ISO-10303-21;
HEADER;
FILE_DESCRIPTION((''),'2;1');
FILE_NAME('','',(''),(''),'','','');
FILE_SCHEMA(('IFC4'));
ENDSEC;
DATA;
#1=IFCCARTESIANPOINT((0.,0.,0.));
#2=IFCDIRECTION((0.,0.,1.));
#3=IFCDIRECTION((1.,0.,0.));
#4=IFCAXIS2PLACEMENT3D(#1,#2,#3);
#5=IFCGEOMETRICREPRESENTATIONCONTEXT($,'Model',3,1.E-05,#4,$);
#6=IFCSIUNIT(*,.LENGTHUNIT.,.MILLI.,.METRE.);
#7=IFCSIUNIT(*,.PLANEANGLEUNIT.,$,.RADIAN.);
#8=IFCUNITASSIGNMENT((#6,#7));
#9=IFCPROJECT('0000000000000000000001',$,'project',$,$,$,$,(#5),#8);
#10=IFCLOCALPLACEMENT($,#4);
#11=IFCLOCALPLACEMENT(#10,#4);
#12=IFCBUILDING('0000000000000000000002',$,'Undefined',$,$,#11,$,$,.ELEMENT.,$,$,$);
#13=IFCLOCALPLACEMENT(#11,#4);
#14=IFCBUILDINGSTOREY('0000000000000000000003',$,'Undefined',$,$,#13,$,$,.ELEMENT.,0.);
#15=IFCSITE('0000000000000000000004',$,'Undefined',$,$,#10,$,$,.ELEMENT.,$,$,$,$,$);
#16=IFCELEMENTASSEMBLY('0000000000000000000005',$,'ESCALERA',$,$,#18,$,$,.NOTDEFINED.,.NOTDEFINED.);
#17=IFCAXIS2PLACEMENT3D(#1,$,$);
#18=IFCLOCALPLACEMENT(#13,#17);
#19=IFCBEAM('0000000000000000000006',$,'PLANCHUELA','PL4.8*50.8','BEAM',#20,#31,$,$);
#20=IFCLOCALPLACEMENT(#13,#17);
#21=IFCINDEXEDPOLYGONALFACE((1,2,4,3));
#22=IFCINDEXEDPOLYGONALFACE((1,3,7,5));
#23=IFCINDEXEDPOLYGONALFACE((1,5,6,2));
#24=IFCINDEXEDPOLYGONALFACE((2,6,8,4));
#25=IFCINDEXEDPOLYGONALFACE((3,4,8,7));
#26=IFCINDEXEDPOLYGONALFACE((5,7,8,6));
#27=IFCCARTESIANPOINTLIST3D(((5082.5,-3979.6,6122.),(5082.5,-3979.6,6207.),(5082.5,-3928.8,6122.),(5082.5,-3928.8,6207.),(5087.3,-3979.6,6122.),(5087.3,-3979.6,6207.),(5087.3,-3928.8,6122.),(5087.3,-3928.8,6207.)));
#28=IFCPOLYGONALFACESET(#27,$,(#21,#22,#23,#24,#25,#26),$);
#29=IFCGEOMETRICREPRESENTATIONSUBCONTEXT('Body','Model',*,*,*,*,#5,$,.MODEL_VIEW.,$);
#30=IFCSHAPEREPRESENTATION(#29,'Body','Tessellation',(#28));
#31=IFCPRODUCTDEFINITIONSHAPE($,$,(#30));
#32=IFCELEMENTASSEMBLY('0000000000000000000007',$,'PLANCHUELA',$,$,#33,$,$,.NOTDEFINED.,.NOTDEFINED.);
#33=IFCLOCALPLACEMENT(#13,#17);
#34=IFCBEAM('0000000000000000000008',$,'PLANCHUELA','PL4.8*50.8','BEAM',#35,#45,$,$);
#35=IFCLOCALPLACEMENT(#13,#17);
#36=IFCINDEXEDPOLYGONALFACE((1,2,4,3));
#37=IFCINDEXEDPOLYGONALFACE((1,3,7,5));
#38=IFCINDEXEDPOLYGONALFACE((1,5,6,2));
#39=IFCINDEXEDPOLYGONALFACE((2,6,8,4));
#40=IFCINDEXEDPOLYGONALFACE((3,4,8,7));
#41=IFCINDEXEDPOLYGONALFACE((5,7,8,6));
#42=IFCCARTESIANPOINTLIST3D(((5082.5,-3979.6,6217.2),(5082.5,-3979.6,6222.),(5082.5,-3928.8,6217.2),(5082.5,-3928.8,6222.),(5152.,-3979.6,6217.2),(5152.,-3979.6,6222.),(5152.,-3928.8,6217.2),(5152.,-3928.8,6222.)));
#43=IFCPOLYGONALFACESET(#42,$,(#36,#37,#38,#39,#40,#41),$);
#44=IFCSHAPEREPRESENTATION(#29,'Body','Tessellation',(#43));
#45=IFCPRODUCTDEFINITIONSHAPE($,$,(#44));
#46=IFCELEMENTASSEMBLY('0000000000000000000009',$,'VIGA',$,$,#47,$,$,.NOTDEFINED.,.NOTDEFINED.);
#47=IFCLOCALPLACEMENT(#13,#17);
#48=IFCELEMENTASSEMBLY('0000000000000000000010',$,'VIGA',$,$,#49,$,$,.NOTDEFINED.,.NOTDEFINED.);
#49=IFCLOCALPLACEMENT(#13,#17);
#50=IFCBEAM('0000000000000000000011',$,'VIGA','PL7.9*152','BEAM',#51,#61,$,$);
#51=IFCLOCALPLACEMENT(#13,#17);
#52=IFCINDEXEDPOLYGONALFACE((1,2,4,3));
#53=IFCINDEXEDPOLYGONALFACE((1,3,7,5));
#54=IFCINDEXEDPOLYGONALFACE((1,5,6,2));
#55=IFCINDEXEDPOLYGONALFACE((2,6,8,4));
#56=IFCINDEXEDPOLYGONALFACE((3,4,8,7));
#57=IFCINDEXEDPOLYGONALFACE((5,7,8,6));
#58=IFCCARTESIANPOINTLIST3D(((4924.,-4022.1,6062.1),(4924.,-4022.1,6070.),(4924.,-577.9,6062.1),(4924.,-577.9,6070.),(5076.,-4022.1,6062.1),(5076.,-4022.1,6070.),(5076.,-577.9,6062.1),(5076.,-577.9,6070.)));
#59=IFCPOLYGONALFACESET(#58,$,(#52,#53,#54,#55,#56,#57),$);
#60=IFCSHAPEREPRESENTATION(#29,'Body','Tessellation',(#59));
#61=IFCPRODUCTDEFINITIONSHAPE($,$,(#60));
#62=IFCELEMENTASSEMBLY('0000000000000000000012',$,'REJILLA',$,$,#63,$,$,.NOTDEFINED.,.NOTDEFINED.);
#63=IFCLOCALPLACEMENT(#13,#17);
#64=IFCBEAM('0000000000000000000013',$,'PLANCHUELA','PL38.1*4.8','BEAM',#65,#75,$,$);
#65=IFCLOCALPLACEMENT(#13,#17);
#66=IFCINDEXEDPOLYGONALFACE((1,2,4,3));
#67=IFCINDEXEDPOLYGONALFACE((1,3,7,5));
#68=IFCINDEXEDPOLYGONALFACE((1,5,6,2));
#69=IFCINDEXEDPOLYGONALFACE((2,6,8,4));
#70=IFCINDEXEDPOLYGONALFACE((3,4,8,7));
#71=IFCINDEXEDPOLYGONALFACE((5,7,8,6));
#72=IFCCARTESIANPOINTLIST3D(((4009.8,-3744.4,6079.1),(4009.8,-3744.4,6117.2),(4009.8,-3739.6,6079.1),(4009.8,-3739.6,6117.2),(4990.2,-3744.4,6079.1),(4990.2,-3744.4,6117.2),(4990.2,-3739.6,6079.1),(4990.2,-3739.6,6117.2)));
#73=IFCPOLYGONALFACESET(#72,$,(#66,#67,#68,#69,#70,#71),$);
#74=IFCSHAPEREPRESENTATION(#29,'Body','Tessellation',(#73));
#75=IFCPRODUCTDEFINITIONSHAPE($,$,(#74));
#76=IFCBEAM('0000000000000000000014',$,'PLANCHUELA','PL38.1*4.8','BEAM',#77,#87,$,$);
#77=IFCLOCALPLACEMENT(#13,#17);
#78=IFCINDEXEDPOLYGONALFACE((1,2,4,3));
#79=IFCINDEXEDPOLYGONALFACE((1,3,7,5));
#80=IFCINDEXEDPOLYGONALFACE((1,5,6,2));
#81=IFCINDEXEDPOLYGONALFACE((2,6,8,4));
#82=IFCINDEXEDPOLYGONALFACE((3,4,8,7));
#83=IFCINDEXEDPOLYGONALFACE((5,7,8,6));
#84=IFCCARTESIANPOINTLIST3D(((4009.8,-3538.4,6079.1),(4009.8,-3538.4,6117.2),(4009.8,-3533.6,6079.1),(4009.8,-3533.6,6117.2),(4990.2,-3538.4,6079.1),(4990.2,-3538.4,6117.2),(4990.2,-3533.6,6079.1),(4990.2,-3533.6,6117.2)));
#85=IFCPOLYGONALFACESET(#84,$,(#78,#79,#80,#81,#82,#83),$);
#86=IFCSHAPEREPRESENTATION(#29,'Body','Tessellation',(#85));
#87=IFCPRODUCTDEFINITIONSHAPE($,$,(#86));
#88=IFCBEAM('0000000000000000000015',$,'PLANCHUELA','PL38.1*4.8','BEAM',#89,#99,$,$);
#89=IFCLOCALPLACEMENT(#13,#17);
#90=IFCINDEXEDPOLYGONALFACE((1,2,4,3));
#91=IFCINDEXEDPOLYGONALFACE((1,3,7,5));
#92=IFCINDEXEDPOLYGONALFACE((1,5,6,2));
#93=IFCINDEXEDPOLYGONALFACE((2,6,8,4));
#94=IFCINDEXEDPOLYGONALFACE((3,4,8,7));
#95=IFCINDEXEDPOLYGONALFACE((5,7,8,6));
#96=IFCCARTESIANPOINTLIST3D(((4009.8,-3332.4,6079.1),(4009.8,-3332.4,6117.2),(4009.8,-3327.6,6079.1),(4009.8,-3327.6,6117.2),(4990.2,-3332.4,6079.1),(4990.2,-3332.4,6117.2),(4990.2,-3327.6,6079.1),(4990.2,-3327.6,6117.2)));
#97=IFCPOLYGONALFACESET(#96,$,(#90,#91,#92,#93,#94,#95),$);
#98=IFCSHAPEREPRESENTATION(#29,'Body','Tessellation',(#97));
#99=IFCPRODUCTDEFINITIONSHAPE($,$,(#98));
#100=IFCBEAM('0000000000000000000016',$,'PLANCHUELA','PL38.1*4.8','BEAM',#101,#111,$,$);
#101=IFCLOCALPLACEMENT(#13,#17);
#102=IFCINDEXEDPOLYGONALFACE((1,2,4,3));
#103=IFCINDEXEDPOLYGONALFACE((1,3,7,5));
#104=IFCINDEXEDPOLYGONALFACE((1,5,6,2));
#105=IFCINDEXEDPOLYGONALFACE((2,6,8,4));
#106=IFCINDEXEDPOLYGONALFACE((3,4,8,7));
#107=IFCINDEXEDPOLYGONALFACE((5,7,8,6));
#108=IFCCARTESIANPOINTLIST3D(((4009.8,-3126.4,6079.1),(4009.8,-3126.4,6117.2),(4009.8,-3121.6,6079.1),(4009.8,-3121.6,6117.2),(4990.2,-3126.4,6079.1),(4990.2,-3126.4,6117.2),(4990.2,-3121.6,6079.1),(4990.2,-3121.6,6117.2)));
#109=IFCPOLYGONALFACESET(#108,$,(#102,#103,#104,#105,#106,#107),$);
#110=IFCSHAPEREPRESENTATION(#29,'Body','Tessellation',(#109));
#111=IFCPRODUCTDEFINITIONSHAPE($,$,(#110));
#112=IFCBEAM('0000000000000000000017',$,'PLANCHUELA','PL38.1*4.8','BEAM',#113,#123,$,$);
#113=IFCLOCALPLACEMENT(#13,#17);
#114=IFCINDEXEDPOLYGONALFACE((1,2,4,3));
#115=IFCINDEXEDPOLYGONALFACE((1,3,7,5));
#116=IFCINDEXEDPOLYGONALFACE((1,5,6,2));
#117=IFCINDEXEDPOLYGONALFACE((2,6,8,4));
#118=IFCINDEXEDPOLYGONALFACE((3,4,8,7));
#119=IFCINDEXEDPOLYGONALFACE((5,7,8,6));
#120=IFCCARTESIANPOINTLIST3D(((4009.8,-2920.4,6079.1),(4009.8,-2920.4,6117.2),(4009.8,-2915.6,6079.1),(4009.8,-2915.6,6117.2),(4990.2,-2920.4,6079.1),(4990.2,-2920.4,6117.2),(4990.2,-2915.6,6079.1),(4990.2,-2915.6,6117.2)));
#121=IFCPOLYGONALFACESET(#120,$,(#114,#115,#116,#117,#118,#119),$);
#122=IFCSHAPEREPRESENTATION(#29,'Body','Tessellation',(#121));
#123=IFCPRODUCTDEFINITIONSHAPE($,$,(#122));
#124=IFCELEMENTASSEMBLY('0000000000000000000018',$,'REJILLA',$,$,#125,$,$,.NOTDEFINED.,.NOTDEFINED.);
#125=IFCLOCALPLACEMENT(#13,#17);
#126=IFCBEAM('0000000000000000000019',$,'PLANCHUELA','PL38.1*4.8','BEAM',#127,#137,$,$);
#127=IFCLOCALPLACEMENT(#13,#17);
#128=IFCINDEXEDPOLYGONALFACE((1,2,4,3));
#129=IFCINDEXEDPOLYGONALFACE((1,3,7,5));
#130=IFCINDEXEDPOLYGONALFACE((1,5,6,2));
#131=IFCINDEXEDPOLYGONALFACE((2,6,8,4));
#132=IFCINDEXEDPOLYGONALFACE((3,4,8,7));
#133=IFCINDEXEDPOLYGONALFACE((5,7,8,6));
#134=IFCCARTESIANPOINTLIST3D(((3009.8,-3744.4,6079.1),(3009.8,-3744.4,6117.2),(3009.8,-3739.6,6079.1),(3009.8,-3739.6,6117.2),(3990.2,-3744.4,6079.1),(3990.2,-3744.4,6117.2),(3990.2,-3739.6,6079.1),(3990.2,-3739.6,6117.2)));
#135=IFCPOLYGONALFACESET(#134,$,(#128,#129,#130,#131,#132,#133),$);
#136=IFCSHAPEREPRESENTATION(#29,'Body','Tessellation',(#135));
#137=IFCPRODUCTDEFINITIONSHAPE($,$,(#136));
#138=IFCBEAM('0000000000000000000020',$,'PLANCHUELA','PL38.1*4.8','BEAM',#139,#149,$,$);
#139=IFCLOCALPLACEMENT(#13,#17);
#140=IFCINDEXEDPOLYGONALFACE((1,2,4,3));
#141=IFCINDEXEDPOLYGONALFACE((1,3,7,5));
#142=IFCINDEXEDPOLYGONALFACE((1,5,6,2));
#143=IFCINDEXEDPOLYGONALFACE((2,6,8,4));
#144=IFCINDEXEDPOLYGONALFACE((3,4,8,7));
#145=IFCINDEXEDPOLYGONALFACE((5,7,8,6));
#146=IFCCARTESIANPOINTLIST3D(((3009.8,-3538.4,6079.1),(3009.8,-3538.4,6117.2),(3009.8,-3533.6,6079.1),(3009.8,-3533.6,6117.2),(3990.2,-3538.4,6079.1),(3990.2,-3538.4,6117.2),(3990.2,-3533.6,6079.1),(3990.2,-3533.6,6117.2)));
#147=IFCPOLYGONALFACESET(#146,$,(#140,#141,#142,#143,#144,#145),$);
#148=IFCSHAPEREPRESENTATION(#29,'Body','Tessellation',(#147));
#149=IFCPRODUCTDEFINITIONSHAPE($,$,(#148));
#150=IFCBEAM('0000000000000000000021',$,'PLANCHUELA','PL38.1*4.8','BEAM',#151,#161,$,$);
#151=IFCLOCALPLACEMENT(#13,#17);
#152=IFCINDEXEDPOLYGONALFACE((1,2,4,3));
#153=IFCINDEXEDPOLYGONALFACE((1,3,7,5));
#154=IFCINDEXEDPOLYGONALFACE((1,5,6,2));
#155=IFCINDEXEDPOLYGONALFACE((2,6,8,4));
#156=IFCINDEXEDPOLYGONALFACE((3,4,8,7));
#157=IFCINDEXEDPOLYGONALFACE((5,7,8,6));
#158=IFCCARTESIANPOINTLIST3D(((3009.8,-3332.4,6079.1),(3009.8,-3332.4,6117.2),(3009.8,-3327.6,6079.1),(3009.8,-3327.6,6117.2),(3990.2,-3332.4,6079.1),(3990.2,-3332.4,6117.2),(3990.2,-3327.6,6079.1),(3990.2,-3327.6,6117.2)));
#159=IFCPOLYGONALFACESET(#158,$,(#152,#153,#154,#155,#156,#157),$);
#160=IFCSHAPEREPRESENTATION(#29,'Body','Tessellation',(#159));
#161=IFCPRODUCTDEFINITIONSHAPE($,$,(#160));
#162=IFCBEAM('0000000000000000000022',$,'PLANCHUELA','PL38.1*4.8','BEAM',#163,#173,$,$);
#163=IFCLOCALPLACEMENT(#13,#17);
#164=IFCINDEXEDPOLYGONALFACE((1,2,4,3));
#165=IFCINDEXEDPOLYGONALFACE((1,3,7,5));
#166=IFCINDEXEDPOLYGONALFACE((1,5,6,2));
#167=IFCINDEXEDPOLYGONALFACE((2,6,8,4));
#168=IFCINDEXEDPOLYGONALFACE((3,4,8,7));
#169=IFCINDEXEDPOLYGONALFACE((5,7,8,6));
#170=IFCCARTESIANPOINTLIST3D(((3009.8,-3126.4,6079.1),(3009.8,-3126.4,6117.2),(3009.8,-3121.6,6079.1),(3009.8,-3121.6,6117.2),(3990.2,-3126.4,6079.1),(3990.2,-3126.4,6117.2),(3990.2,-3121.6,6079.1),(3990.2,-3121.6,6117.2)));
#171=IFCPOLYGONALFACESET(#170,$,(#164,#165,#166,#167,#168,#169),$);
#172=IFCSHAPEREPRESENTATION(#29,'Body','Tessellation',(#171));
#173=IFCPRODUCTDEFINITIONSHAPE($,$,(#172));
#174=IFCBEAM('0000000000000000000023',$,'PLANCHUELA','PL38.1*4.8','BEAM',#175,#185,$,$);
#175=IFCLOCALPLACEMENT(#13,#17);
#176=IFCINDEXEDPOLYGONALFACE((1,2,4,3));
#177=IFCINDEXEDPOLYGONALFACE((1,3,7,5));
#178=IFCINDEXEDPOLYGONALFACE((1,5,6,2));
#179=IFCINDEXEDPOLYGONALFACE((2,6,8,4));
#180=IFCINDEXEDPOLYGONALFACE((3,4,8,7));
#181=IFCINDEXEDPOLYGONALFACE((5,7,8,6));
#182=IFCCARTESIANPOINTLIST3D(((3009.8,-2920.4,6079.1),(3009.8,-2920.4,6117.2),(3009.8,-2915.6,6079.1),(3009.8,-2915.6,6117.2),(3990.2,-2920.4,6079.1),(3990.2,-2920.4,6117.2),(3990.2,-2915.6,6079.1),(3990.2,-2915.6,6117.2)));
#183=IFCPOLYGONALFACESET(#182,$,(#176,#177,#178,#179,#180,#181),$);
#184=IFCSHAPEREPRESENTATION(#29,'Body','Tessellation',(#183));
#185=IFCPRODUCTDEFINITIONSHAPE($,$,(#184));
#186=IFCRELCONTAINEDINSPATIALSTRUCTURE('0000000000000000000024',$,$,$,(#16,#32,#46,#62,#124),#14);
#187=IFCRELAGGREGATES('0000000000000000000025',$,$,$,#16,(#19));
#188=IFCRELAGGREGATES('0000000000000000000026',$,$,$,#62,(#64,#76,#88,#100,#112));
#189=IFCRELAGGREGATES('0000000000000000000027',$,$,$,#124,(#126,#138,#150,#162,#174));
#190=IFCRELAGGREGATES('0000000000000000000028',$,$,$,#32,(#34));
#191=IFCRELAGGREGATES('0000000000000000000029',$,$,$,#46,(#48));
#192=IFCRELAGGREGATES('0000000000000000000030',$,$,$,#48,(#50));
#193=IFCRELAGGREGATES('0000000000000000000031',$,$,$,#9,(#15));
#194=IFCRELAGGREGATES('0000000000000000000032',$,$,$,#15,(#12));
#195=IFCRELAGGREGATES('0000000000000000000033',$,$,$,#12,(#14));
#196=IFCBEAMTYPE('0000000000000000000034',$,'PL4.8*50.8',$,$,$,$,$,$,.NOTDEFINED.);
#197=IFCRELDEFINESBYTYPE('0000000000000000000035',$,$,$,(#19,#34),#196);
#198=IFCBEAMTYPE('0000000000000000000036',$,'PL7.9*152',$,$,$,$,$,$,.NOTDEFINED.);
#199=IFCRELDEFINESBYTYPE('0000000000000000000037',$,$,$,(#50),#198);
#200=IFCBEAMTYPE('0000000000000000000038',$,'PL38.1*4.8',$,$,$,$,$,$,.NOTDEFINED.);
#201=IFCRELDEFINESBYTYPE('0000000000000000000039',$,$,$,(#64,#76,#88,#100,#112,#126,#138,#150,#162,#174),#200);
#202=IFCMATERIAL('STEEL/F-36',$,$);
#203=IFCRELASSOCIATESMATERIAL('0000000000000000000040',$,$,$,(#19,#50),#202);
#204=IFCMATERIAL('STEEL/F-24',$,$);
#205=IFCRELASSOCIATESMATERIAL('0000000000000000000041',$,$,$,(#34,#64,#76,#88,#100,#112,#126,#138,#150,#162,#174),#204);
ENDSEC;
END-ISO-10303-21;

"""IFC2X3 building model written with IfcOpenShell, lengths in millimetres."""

from ifc_helpers import new_model, si_unit, frame, origin_with_axes, origin_2d_with_axis, place, context, subcontext, project, spatial, rectangle, extrude, material, type_object, element, aggregate, save


model = new_model("IFC2X3")

# Units and contexts
model_context = context("Model", 3, precision=1e-05, world=origin_with_axes())
body_context = subcontext(model_context, "Body", "Model", "MODEL_VIEW")
ifc_project = project(units=[si_unit("LENGTHUNIT", "METRE", prefix="MILLI"), si_unit("PLANEANGLEUNIT", "RADIAN")], contexts=[model_context])

# Site, building, storey
site_placement = place(None, origin_with_axes())
site = spatial("IfcSite", under=ifc_project, at=site_placement, Name="Undefined", CompositionType="ELEMENT")
building_placement = place(site_placement, origin_with_axes())
building = spatial("IfcBuilding", under=site, at=building_placement, Name="Undefined", CompositionType="ELEMENT")
storey_placement = place(building_placement, origin_with_axes())
storey = spatial("IfcBuildingStorey", under=building, at=storey_placement, Name="Undefined", CompositionType="ELEMENT", Elevation=0.0)

# Element assemblies, beams
assembly_1_placement = place(storey_placement, origin_with_axes())
assembly_1 = element("IfcElementAssembly", 1, at=assembly_1_placement, inside=storey, Name="ESCALERA", AssemblyPlace="NOTDEFINED", PredefinedType="NOTDEFINED")
ifc_material_1 = material(Name="STEEL/F-36")
beam_type_1 = type_object("IfcBeamType", Name="PL4.8*50.8", PredefinedType="NOTDEFINED")
beam_1_placement = place(assembly_1_placement, frame((5084.9, -3954.2, 6207.0), z_axis=(0.0, -1.0, 0.0), x_axis=(0.0, 0.0, -1.0)))
beam_1 = element("IfcBeam", 2, at=beam_1_placement, type_object=beam_type_1, material=ifc_material_1, Name="PLANCHUELA", Description="PL4.8*50.8", ObjectType="BEAM", context=body_context, shape_type="SweptSolid", body=[
    extrude(rectangle(XDim=4.8, YDim=50.8, at=origin_2d_with_axis()), frame((85.0, 0.0, 0.0), z_axis=(-1.0, 0.0, 0.0), x_axis=(0.0, -1.0, 0.0)), (0.0, 0.0, 1.0), 85.0),
])
aggregate(assembly_1, [beam_1])
assembly_2_placement = place(storey_placement, origin_with_axes())
assembly_2 = element("IfcElementAssembly", 3, at=assembly_2_placement, inside=storey, Name="PLANCHUELA", AssemblyPlace="NOTDEFINED", PredefinedType="NOTDEFINED")
ifc_material_2 = material(Name="STEEL/F-24")
beam_2_placement = place(assembly_2_placement, frame((5082.5, -3954.2, 6219.6), z_axis=(0.0, -1.0, 0.0), x_axis=(1.0, 0.0, 0.0)))
beam_2 = element("IfcBeam", 4, at=beam_2_placement, type_object=beam_type_1, material=ifc_material_2, Name="PLANCHUELA", Description="PL4.8*50.8", ObjectType="BEAM", context=body_context, shape_type="SweptSolid", body=[
    extrude(rectangle(XDim=4.8, YDim=50.8, at=origin_2d_with_axis()), frame((69.4, 0.0, 0.0), z_axis=(-1.0, 0.0, 0.0), x_axis=(0.0, -1.0, 0.0)), (0.0, 0.0, 1.0), 69.4),
])

# Element assemblies, beam
assembly_3_placement = place(storey_placement, origin_with_axes())
assembly_3 = element("IfcElementAssembly", 5, at=assembly_3_placement, inside=storey, Name="VIGA", AssemblyPlace="NOTDEFINED", PredefinedType="NOTDEFINED")
assembly_4_placement = place(assembly_3_placement, origin_with_axes())
assembly_4 = element("IfcElementAssembly", 6, at=assembly_4_placement, Name="VIGA", AssemblyPlace="NOTDEFINED", PredefinedType="NOTDEFINED")
beam_type_2 = type_object("IfcBeamType", Name="PL7.9*152", PredefinedType="NOTDEFINED")
beam_3_placement = place(assembly_4_placement, frame((5000.0, -4022.1, 6066.1), z_axis=(-1.0, 0.0, 0.0), x_axis=(0.0, 1.0, 0.0)))
beam_3 = element("IfcBeam", 7, at=beam_3_placement, type_object=beam_type_2, material=ifc_material_1, Name="VIGA", Description="PL7.9*152", ObjectType="BEAM", context=body_context, shape_type="SweptSolid", body=[
    extrude(rectangle(XDim=7.9, YDim=152.0, at=origin_2d_with_axis()), frame((3444.2, 0.0, 0.0), z_axis=(-1.0, 0.0, 0.0), x_axis=(0.0, -1.0, 0.0)), (0.0, 0.0, 1.0), 3444.2),
])

# Element assemblies, beams
assembly_5_placement = place(storey_placement, origin_with_axes())
assembly_5 = element("IfcElementAssembly", 8, at=assembly_5_placement, inside=storey, Name="REJILLA", AssemblyPlace="NOTDEFINED", PredefinedType="NOTDEFINED")
beam_type_3 = type_object("IfcBeamType", Name="PL38.1*4.8", PredefinedType="NOTDEFINED")
beam_4_placement = place(assembly_5_placement, frame((4990.2, -3742.0, 6098.2), z_axis=(-0.000041, 0.0, -1.0), x_axis=(-1.0, 0.0, 0.000041)))
beam_4 = element("IfcBeam", 9, at=beam_4_placement, type_object=beam_type_3, material=ifc_material_2, Name="PLANCHUELA", Description="PL38.1*4.8", ObjectType="BEAM", context=body_context, shape_type="SweptSolid", body=[
    extrude(rectangle(XDim=4.8, YDim=38.1, at=origin_2d_with_axis()), frame((980.4, 0.0, 0.0), z_axis=(-1.0, 0.0, 0.0), x_axis=(0.0, -1.0, 0.0)), (0.0, 0.0, 1.0), 980.4),
])
beam_5_placement = place(assembly_5_placement, frame((4990.2, -3536.0, 6098.2), z_axis=(-0.000041, 0.0, -1.0), x_axis=(-1.0, 0.0, 0.000041)))
beam_5 = element("IfcBeam", 10, at=beam_5_placement, type_object=beam_type_3, material=ifc_material_2, Name="PLANCHUELA", Description="PL38.1*4.8", ObjectType="BEAM", context=body_context, shape_type="SweptSolid", body=[
    extrude(rectangle(XDim=4.8, YDim=38.1, at=origin_2d_with_axis()), frame((980.4, 0.0, 0.0), z_axis=(-1.0, 0.0, 0.0), x_axis=(0.0, -1.0, 0.0)), (0.0, 0.0, 1.0), 980.4),
])
beam_6_placement = place(assembly_5_placement, frame((4990.2, -3330.0, 6098.2), z_axis=(-0.000041, 0.0, -1.0), x_axis=(-1.0, 0.0, 0.000041)))
beam_6 = element("IfcBeam", 11, at=beam_6_placement, type_object=beam_type_3, material=ifc_material_2, Name="PLANCHUELA", Description="PL38.1*4.8", ObjectType="BEAM", context=body_context, shape_type="SweptSolid", body=[
    extrude(rectangle(XDim=4.8, YDim=38.1, at=origin_2d_with_axis()), frame((980.4, 0.0, 0.0), z_axis=(-1.0, 0.0, 0.0), x_axis=(0.0, -1.0, 0.0)), (0.0, 0.0, 1.0), 980.4),
])
beam_7_placement = place(assembly_5_placement, frame((4990.2, -3124.0, 6098.2), z_axis=(-0.000041, 0.0, -1.0), x_axis=(-1.0, 0.0, 0.000041)))
beam_7 = element("IfcBeam", 12, at=beam_7_placement, type_object=beam_type_3, material=ifc_material_2, Name="PLANCHUELA", Description="PL38.1*4.8", ObjectType="BEAM", context=body_context, shape_type="SweptSolid", body=[
    extrude(rectangle(XDim=4.8, YDim=38.1, at=origin_2d_with_axis()), frame((980.4, 0.0, 0.0), z_axis=(-1.0, 0.0, 0.0), x_axis=(0.0, -1.0, 0.0)), (0.0, 0.0, 1.0), 980.4),
])
beam_8_placement = place(assembly_5_placement, frame((4990.2, -2918.0, 6098.2), z_axis=(-0.000041, 0.0, -1.0), x_axis=(-1.0, 0.0, 0.000041)))
beam_8 = element("IfcBeam", 13, at=beam_8_placement, type_object=beam_type_3, material=ifc_material_2, Name="PLANCHUELA", Description="PL38.1*4.8", ObjectType="BEAM", context=body_context, shape_type="SweptSolid", body=[
    extrude(rectangle(XDim=4.8, YDim=38.1, at=origin_2d_with_axis()), frame((980.4, 0.0, 0.0), z_axis=(-1.0, 0.0, 0.0), x_axis=(0.0, -1.0, 0.0)), (0.0, 0.0, 1.0), 980.4),
])
assembly_6_placement = place(storey_placement, origin_with_axes())
assembly_6 = element("IfcElementAssembly", 14, at=assembly_6_placement, inside=storey, Name="REJILLA", AssemblyPlace="NOTDEFINED", PredefinedType="NOTDEFINED")
beam_9_placement = place(assembly_6_placement, frame((3990.2, -3742.0, 6098.2), z_axis=(-0.000041, 0.0, -1.0), x_axis=(-1.0, 0.0, 0.000041)))
beam_9 = element("IfcBeam", 15, at=beam_9_placement, type_object=beam_type_3, material=ifc_material_2, Name="PLANCHUELA", Description="PL38.1*4.8", ObjectType="BEAM", context=body_context, shape_type="SweptSolid", body=[
    extrude(rectangle(XDim=4.8, YDim=38.1, at=origin_2d_with_axis()), frame((980.4, 0.0, 0.0), z_axis=(-1.0, 0.0, 0.0), x_axis=(0.0, -1.0, 0.0)), (0.0, 0.0, 1.0), 980.4),
])
beam_10_placement = place(assembly_6_placement, frame((3990.2, -3536.0, 6098.2), z_axis=(-0.000041, 0.0, -1.0), x_axis=(-1.0, 0.0, 0.000041)))
beam_10 = element("IfcBeam", 16, at=beam_10_placement, type_object=beam_type_3, material=ifc_material_2, Name="PLANCHUELA", Description="PL38.1*4.8", ObjectType="BEAM", context=body_context, shape_type="SweptSolid", body=[
    extrude(rectangle(XDim=4.8, YDim=38.1, at=origin_2d_with_axis()), frame((980.4, 0.0, 0.0), z_axis=(-1.0, 0.0, 0.0), x_axis=(0.0, -1.0, 0.0)), (0.0, 0.0, 1.0), 980.4),
])
beam_11_placement = place(assembly_6_placement, frame((3990.2, -3330.0, 6098.2), z_axis=(-0.000041, 0.0, -1.0), x_axis=(-1.0, 0.0, 0.000041)))
beam_11 = element("IfcBeam", 17, at=beam_11_placement, type_object=beam_type_3, material=ifc_material_2, Name="PLANCHUELA", Description="PL38.1*4.8", ObjectType="BEAM", context=body_context, shape_type="SweptSolid", body=[
    extrude(rectangle(XDim=4.8, YDim=38.1, at=origin_2d_with_axis()), frame((980.4, 0.0, 0.0), z_axis=(-1.0, 0.0, 0.0), x_axis=(0.0, -1.0, 0.0)), (0.0, 0.0, 1.0), 980.4),
])
beam_12_placement = place(assembly_6_placement, frame((3990.2, -3124.0, 6098.2), z_axis=(-0.000041, 0.0, -1.0), x_axis=(-1.0, 0.0, 0.000041)))
beam_12 = element("IfcBeam", 18, at=beam_12_placement, type_object=beam_type_3, material=ifc_material_2, Name="PLANCHUELA", Description="PL38.1*4.8", ObjectType="BEAM", context=body_context, shape_type="SweptSolid", body=[
    extrude(rectangle(XDim=4.8, YDim=38.1, at=origin_2d_with_axis()), frame((980.4, 0.0, 0.0), z_axis=(-1.0, 0.0, 0.0), x_axis=(0.0, -1.0, 0.0)), (0.0, 0.0, 1.0), 980.4),
])
beam_13_placement = place(assembly_6_placement, frame((3990.2, -2918.0, 6098.2), z_axis=(-0.000041, 0.0, -1.0), x_axis=(-1.0, 0.0, 0.000041)))
beam_13 = element("IfcBeam", 19, at=beam_13_placement, type_object=beam_type_3, material=ifc_material_2, Name="PLANCHUELA", Description="PL38.1*4.8", ObjectType="BEAM", context=body_context, shape_type="SweptSolid", body=[
    extrude(rectangle(XDim=4.8, YDim=38.1, at=origin_2d_with_axis()), frame((980.4, 0.0, 0.0), z_axis=(-1.0, 0.0, 0.0), x_axis=(0.0, -1.0, 0.0)), (0.0, 0.0, 1.0), 980.4),
])

aggregate(assembly_5, [beam_4, beam_5, beam_6, beam_7, beam_8])
aggregate(assembly_6, [beam_9, beam_10, beam_11, beam_12, beam_13])

aggregate(assembly_2, [beam_2])
aggregate(assembly_3, [assembly_4])

aggregate(assembly_4, [beam_3])

save(model, "model.ifc")
